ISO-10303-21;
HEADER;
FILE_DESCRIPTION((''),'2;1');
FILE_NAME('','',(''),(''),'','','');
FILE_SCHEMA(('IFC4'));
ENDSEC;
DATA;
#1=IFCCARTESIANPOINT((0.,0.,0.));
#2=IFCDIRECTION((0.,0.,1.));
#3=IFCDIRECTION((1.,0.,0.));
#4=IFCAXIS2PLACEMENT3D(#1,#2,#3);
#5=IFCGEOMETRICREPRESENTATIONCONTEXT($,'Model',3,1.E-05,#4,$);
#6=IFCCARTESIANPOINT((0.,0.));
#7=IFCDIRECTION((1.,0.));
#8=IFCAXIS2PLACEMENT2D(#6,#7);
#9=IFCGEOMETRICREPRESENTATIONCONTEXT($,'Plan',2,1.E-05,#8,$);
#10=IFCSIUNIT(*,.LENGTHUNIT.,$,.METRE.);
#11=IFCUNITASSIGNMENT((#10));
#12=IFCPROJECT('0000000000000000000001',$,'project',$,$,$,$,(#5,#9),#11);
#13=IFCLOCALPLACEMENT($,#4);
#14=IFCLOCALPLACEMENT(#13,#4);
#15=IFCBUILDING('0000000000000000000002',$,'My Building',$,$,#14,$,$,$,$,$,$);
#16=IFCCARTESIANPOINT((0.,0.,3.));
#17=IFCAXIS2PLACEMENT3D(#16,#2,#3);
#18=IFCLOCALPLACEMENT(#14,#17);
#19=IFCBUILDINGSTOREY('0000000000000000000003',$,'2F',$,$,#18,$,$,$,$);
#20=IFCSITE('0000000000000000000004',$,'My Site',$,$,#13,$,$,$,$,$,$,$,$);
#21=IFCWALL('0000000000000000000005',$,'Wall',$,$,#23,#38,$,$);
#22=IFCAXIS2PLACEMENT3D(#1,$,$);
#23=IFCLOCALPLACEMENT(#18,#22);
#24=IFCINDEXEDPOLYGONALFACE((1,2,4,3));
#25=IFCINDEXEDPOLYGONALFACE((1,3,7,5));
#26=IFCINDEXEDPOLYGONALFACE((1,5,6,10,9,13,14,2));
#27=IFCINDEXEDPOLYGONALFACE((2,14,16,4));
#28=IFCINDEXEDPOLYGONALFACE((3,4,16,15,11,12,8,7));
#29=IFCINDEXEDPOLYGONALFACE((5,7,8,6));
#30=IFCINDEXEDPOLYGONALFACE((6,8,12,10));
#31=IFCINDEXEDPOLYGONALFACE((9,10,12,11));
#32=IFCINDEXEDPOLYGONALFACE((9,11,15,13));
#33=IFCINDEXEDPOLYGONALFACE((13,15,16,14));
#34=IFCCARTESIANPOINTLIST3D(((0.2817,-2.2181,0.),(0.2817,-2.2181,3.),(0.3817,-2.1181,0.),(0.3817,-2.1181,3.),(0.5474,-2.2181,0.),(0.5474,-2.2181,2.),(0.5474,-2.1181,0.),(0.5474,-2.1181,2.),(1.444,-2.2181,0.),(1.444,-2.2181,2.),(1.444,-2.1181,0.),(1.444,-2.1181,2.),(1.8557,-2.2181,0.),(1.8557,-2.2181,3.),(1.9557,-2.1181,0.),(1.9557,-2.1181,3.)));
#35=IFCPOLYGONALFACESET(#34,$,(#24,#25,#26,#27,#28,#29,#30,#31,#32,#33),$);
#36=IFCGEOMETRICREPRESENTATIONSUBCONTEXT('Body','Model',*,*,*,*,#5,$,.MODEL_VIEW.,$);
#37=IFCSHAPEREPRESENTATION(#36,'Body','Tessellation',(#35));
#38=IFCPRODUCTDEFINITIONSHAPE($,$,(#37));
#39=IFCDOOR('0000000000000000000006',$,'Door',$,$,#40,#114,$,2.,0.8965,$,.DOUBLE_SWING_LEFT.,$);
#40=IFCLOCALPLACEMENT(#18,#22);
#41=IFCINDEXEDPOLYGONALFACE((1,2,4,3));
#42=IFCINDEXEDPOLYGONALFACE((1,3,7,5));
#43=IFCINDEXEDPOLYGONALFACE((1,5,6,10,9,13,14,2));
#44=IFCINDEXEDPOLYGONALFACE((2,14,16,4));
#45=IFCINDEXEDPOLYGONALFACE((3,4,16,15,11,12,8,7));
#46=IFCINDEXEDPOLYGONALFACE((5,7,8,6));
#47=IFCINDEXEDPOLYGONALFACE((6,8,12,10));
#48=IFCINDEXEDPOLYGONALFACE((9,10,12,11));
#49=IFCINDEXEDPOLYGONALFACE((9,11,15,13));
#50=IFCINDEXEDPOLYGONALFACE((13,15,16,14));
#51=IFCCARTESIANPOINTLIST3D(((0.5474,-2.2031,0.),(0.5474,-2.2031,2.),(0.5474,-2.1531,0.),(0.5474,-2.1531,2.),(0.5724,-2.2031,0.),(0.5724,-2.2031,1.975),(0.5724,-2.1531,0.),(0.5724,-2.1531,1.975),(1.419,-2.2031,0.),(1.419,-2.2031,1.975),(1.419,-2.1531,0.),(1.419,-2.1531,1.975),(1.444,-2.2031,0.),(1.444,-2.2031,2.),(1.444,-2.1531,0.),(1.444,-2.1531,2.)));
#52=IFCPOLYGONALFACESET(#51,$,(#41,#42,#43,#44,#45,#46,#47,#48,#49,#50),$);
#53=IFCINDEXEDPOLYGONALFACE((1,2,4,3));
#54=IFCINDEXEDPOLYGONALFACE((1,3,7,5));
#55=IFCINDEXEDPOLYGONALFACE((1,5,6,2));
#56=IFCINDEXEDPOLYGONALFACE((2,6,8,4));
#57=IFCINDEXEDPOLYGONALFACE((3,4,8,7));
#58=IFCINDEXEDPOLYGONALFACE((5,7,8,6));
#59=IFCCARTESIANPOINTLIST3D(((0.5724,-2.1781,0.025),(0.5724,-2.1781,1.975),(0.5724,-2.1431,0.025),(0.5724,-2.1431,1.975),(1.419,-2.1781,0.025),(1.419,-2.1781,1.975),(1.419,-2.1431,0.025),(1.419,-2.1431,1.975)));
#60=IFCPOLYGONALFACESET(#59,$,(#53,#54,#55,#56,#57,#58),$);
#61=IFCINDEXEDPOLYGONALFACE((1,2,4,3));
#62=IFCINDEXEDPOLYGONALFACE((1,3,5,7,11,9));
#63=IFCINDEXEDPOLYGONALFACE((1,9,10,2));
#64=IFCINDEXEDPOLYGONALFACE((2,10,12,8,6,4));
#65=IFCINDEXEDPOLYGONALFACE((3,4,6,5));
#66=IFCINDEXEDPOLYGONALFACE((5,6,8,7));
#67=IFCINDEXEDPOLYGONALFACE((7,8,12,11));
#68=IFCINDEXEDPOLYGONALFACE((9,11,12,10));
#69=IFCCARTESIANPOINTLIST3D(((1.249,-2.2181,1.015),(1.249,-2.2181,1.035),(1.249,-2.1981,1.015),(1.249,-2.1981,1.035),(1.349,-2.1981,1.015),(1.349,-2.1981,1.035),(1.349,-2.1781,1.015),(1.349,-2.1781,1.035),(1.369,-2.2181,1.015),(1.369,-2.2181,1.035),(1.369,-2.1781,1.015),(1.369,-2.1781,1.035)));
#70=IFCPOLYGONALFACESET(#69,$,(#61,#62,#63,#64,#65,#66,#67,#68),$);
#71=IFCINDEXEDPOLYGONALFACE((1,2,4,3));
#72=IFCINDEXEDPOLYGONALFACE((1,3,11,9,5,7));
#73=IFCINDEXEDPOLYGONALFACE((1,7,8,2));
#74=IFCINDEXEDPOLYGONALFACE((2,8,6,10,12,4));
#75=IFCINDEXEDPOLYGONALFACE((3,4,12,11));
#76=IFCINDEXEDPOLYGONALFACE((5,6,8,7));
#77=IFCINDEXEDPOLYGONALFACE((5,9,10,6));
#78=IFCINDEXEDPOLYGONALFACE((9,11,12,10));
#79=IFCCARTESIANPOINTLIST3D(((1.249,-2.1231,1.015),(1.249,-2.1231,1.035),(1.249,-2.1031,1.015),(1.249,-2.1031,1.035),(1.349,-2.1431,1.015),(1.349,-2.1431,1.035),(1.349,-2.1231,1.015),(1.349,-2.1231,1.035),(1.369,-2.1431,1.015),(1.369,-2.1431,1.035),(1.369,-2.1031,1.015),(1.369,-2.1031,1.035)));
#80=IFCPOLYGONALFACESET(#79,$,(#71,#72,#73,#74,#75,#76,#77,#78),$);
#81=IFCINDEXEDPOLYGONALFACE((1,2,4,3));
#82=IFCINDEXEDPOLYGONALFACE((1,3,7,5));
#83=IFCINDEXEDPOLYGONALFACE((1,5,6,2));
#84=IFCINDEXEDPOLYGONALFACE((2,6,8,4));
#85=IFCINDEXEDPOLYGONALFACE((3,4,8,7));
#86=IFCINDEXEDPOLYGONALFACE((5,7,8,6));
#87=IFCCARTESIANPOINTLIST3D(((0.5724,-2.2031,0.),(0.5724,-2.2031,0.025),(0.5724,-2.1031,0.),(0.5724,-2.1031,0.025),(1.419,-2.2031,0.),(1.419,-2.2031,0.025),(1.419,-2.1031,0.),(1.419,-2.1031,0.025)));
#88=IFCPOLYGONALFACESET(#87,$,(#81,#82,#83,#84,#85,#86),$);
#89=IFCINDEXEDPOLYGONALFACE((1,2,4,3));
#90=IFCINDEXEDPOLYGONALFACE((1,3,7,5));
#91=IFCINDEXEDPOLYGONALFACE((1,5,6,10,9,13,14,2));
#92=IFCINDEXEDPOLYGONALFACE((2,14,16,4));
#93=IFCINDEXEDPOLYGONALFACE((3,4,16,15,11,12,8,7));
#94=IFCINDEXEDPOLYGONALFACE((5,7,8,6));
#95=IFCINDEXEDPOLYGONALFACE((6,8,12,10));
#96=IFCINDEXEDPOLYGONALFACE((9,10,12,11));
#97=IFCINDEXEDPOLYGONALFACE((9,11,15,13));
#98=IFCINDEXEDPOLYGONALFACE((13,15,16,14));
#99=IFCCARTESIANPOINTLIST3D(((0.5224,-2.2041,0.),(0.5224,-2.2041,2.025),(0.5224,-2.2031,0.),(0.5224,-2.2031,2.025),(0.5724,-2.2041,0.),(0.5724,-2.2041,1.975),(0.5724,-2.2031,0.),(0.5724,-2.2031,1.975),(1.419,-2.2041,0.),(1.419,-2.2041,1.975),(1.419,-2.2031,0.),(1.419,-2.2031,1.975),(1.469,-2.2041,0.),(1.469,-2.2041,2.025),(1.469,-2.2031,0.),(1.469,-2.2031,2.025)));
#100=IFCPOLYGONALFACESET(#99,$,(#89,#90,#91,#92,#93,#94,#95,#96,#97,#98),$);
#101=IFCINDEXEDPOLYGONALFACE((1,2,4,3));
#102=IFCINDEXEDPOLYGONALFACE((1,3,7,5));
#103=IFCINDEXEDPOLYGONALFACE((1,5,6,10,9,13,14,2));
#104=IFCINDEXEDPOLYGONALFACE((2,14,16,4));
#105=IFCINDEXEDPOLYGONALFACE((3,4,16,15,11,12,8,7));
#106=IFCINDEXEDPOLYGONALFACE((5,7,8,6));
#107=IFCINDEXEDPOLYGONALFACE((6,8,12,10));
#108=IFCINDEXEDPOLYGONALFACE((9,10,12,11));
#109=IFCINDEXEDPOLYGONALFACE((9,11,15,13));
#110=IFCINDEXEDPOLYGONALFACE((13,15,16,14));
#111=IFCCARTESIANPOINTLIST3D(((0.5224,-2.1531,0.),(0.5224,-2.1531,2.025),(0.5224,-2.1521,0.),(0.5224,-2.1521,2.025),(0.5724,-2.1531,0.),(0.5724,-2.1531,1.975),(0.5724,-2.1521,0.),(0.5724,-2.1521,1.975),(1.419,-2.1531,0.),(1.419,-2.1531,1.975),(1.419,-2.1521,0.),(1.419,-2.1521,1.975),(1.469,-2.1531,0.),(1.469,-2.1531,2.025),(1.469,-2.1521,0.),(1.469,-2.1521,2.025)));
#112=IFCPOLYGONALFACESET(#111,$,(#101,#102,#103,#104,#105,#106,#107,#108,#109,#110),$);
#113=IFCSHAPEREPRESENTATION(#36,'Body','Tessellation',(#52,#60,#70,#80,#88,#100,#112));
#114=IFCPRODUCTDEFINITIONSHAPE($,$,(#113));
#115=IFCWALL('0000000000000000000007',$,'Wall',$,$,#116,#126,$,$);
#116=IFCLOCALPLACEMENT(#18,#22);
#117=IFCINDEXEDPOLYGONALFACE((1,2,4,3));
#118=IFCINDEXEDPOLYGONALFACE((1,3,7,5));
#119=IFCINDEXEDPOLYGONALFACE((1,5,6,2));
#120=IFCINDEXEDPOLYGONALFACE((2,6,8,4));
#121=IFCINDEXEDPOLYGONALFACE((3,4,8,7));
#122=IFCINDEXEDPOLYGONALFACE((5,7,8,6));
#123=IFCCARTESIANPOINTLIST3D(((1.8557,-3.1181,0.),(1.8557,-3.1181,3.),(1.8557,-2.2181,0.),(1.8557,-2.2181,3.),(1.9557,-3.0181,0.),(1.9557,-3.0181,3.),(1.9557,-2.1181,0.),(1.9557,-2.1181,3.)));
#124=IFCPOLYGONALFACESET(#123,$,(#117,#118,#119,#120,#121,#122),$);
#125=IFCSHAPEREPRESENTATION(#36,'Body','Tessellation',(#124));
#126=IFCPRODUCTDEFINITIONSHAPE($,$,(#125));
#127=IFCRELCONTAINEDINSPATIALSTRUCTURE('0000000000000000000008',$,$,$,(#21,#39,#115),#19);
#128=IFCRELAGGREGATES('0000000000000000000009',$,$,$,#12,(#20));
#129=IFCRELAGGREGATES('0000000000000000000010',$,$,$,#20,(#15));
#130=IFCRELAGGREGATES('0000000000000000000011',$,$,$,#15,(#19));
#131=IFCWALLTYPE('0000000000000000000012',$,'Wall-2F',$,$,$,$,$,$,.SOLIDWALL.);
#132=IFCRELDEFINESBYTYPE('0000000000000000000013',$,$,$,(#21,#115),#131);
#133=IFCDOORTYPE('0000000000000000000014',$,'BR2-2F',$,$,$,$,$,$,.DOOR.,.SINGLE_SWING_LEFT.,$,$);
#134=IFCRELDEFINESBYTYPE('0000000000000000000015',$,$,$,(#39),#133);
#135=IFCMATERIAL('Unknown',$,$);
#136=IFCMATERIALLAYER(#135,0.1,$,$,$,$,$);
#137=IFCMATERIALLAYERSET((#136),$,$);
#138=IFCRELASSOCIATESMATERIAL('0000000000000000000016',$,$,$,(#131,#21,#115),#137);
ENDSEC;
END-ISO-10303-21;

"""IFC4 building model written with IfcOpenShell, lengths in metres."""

from ifc_helpers import new_model, entity, si_unit, frame, origin_with_axes, origin_2d_with_axis, place, context, subcontext, project, spatial, line, indexed_curve, outline, extrude, shape, source, transform, mapped, material, layer, layer_set, layer_usage, type_object, type_shapes, element, fill, save


model = new_model("IFC4")

# Units and contexts
model_context = context("Model", 3, precision=1e-05, world=origin_with_axes())
plan_context = context("Plan", 2, precision=1e-05, world=origin_2d_with_axis())
body_context_1 = subcontext(model_context, "Body", "Model", "MODEL_VIEW")
body_context_2 = subcontext(plan_context, "Body", "Plan", "PLAN_VIEW")
ifc_project = project(units=[si_unit("LENGTHUNIT", "METRE")], contexts=[model_context, plan_context])

# Site, building, storey
site_placement = place(None, origin_with_axes())
site = spatial("IfcSite", under=ifc_project, at=site_placement, Name="My Site")
building_placement = place(site_placement, origin_with_axes())
building = spatial("IfcBuilding", under=site, at=building_placement, Name="My Building")
storey_placement = place(building_placement, frame((0.0, 0.0, 3.0), z_axis=(0.0, 0.0, 1.0), x_axis=(1.0, 0.0, 0.0)))
storey = spatial("IfcBuildingStorey", under=building, at=storey_placement, Name="2F")

# Shared definitions
ifc_material = material(Name="Unknown")

# Wall, opening, door
shared_shape_1 = source(origin_with_axes(), body_context_1, "Body", "SweptSolid", [
    extrude(outline(indexed_curve([(0.0, 0.0), (0.8965, 0.0), (0.8965, 2.0), (0.0, 2.0)], segments=[line(1, 2, 3, 4, 1)])), frame((0.0, -0.6, 0.0), z_axis=(0.0, -1.0, 0.0), x_axis=(1.0, 0.0, 0.0)), (0.0, 0.0, -1.0), 1.2),
])
door_type_1 = type_object("IfcDoorType", Name="BR2-2F", OperationType="SINGLE_SWING_LEFT", PredefinedType="DOOR")
shared_shape_2 = source(origin_with_axes(), body_context_1, "Body", "SweptSolid", [
    extrude(outline(indexed_curve([(0.0, 0.0), (0.0, 2.0), (0.8965, 2.0), (0.8965, 0.0), (0.8715, 0.0), (0.8715, 1.975), (0.025, 1.975), (0.025, 0.0)], segments=[line(1, 2, 3, 4, 5, 6, 7, 8, 1)])), frame((0.0, 0.0, 0.0), z_axis=(0.0, -1.0, 0.0), x_axis=(1.0, 0.0, 0.0)), (0.0, 0.0, -1.0), 0.05),
    extrude(outline(indexed_curve([(0.0, 0.0), (0.8465, 0.0), (0.8465, 0.035), (0.0, 0.035)], segments=[line(1, 2, 3, 4, 1)])), frame((0.025, 0.025, 0.025), z_axis=(0.0, 0.0, 1.0), x_axis=(1.0, 0.0, 0.0)), (0.0, 0.0, 1.0), 1.95),
    extrude(outline(indexed_curve([(0.0, 0.0), (0.0, -0.04), (-0.12, -0.04), (-0.12, -0.02), (-0.02, -0.02), (-0.02, 0.0)], segments=[line(1, 2, 3, 4, 5, 6, 1)])), frame((0.8215, 0.025, 1.015), z_axis=(0.0, 0.0, 1.0), x_axis=(1.0, 0.0, 0.0)), (0.0, 0.0, 1.0), 0.02),
    extrude(outline(indexed_curve([(0.0, 0.0), (0.0, 0.04), (-0.12, 0.04), (-0.12, 0.02), (-0.02, 0.02), (-0.02, 0.0)], segments=[line(1, 2, 3, 4, 5, 6, 1)])), frame((0.8215, 0.06, 1.015), z_axis=(0.0, 0.0, 1.0), x_axis=(1.0, 0.0, 0.0)), (0.0, 0.0, 1.0), 0.02),
    extrude(outline(indexed_curve([(0.0, 0.0), (0.8465, 0.0), (0.8465, 0.1), (0.0, 0.1)], segments=[line(1, 2, 3, 4, 1)])), frame((0.025, 0.0, 0.0), z_axis=(0.0, 0.0, 1.0), x_axis=(1.0, 0.0, 0.0)), (0.0, 0.0, 1.0), 0.025),
    extrude(outline(indexed_curve([(0.0, 0.0), (0.0, 2.025), (0.9465, 2.025), (0.9465, 0.0), (0.8965, 0.0), (0.8965, 1.975), (0.05, 1.975), (0.05, 0.0)], segments=[line(1, 2, 3, 4, 5, 6, 7, 8, 1)])), frame((-0.025, -0.001, 0.0), z_axis=(0.0, -1.0, 0.0), x_axis=(1.0, 0.0, 0.0)), (0.0, 0.0, -1.0), 0.001),
    extrude(outline(indexed_curve([(0.0, 0.0), (0.0, 2.025), (0.9465, 2.025), (0.9465, 0.0), (0.8965, 0.0), (0.8965, 1.975), (0.05, 1.975), (0.05, 0.0)], segments=[line(1, 2, 3, 4, 5, 6, 7, 8, 1)])), frame((-0.025, 0.05, 0.0), z_axis=(0.0, -1.0, 0.0), x_axis=(1.0, 0.0, 0.0)), (0.0, 0.0, -1.0), 0.001),
])
shared_shape_3 = source(origin_with_axes(), body_context_2, "Body", "Curve2D", [
    entity("IfcIndexedPolyCurve", entity("IfcCartesianPointList2D", [[0.0, 0.0], [0.025, 0.0], [0.025, 0.05], [0.0, 0.05]]), [entity("IfcLineIndex", [1, 2, 3, 4, 1])]),
    entity("IfcIndexedPolyCurve", entity("IfcCartesianPointList2D", [[0.8965, 0.0], [0.8715, 0.0], [0.8715, 0.05], [0.8965, 0.05]]), [entity("IfcLineIndex", [1, 2, 3, 4, 1])]),
    entity("IfcIndexedPolyCurve", entity("IfcCartesianPointList2D", [[0.025, 0.05], [0.025, -0.7965], [0.06, -0.7965]])),
    entity("IfcTrimmedCurve", entity("IfcEllipse", entity("IfcAxis2Placement2D", entity("IfcCartesianPoint", [0.06, 0.05]), entity("IfcDirection", [1.0, 0.0])), 0.8115, 0.8465), [entity("IfcCartesianPoint", [0.06, -0.7965])], [entity("IfcCartesianPoint", [0.06, 0.8965])], True, "CARTESIAN"),
    entity("IfcIndexedPolyCurve", entity("IfcCartesianPointList2D", [[0.025, 0.05], [0.06, 0.05], [0.06, 0.8965], [0.025, 0.8965]]), [entity("IfcLineIndex", [1, 2, 3, 4, 1])]),
])
type_shapes(door_type_1, [shared_shape_2, shared_shape_3])
ifc_layer_1 = layer(ifc_material, 0.1)
ifc_layer_set_1 = layer_set([ifc_layer_1])
wall_type_1 = type_object("IfcWallType", Name="Wall-2F", PredefinedType="SOLIDWALL", material=ifc_layer_set_1)
ifc_layer_usage_1 = layer_usage(ifc_layer_set_1, "AXIS2", "POSITIVE", 0.0)
wall_1_placement = place(storey_placement, frame((0.2817, -2.2181, 0.0), z_axis=(0.0, 0.0, 1.0), x_axis=(1.0, 0.0, 0.0)))
wall_1 = element("IfcWall", 1, at=wall_1_placement, inside=storey, type_object=wall_type_1, material=ifc_layer_usage_1, Name="Wall", context=body_context_1, shape_type="SweptSolid", body=[
    extrude(outline(indexed_curve([(0.0, 0.0), (0.1, 0.1), (1.674, 0.1), (1.574, 0.0)], segments=[line(1, 2, 3, 4, 1)])), origin_with_axes(), (0.0, 0.0, 1.0), 3.0),
])
opening_1_placement = place(wall_1_placement, frame((0.2657, 0.015, 0.0), z_axis=(0.0, 0.0, 1.0), x_axis=(1.0, 0.0, 0.0)))
opening_1 = element("IfcOpeningElement", 2, at=opening_1_placement, cuts=wall_1, PredefinedType="OPENING", context=body_context_1, shape_type="MappedRepresentation", body=[
    mapped(shared_shape_1, transform((0.0, 0.0, 0.0), x_axis=(1.0, 0.0, 0.0), y_axis=(0.0, 1.0, 0.0), z_axis=(0.0, 0.0, 1.0), scale=1.0)),
])
door_1_placement = place(opening_1_placement, origin_with_axes())
door_1 = element("IfcDoor", 3, at=door_1_placement, inside=storey, type_object=door_type_1, Name="Door", OperationType="DOUBLE_SWING_LEFT", OverallHeight=2.0, OverallWidth=0.8965, shapes=[
    shape(body_context_1, "Body", "MappedRepresentation", [mapped(shared_shape_2, transform((0.0, 0.0, 0.0), x_axis=(1.0, 0.0, 0.0), y_axis=(0.0, 1.0, 0.0), z_axis=(0.0, 0.0, 1.0), scale=1.0))]),
    shape(body_context_2, "Body", "MappedRepresentation", [mapped(shared_shape_3, transform((0.0, 0.0, 0.0), x_axis=(1.0, 0.0, 0.0), y_axis=(0.0, 1.0, 0.0), z_axis=(0.0, 0.0, 1.0), scale=1.0))]),
])
fill(opening_1, door_1)

# Wall
ifc_layer_usage_2 = layer_usage(ifc_layer_set_1, "AXIS2", "POSITIVE", 0.0)
wall_2_placement = place(storey_placement, frame((1.8557, -2.2181, 0.0), z_axis=(0.0, 0.0, 1.0), x_axis=(0.0, -1.0, 0.0)))
element("IfcWall", 4, at=wall_2_placement, inside=storey, type_object=wall_type_1, material=ifc_layer_usage_2, Name="Wall", context=body_context_1, shape_type="SweptSolid", body=[
    extrude(outline(indexed_curve([(0.0, 0.0), (-0.1, 0.1), (0.8, 0.1), (0.9, 0.0)], segments=[line(1, 2, 3, 4, 1)])), origin_with_axes(), (0.0, 0.0, 1.0), 3.0),
])

save(model, "model.ifc")
